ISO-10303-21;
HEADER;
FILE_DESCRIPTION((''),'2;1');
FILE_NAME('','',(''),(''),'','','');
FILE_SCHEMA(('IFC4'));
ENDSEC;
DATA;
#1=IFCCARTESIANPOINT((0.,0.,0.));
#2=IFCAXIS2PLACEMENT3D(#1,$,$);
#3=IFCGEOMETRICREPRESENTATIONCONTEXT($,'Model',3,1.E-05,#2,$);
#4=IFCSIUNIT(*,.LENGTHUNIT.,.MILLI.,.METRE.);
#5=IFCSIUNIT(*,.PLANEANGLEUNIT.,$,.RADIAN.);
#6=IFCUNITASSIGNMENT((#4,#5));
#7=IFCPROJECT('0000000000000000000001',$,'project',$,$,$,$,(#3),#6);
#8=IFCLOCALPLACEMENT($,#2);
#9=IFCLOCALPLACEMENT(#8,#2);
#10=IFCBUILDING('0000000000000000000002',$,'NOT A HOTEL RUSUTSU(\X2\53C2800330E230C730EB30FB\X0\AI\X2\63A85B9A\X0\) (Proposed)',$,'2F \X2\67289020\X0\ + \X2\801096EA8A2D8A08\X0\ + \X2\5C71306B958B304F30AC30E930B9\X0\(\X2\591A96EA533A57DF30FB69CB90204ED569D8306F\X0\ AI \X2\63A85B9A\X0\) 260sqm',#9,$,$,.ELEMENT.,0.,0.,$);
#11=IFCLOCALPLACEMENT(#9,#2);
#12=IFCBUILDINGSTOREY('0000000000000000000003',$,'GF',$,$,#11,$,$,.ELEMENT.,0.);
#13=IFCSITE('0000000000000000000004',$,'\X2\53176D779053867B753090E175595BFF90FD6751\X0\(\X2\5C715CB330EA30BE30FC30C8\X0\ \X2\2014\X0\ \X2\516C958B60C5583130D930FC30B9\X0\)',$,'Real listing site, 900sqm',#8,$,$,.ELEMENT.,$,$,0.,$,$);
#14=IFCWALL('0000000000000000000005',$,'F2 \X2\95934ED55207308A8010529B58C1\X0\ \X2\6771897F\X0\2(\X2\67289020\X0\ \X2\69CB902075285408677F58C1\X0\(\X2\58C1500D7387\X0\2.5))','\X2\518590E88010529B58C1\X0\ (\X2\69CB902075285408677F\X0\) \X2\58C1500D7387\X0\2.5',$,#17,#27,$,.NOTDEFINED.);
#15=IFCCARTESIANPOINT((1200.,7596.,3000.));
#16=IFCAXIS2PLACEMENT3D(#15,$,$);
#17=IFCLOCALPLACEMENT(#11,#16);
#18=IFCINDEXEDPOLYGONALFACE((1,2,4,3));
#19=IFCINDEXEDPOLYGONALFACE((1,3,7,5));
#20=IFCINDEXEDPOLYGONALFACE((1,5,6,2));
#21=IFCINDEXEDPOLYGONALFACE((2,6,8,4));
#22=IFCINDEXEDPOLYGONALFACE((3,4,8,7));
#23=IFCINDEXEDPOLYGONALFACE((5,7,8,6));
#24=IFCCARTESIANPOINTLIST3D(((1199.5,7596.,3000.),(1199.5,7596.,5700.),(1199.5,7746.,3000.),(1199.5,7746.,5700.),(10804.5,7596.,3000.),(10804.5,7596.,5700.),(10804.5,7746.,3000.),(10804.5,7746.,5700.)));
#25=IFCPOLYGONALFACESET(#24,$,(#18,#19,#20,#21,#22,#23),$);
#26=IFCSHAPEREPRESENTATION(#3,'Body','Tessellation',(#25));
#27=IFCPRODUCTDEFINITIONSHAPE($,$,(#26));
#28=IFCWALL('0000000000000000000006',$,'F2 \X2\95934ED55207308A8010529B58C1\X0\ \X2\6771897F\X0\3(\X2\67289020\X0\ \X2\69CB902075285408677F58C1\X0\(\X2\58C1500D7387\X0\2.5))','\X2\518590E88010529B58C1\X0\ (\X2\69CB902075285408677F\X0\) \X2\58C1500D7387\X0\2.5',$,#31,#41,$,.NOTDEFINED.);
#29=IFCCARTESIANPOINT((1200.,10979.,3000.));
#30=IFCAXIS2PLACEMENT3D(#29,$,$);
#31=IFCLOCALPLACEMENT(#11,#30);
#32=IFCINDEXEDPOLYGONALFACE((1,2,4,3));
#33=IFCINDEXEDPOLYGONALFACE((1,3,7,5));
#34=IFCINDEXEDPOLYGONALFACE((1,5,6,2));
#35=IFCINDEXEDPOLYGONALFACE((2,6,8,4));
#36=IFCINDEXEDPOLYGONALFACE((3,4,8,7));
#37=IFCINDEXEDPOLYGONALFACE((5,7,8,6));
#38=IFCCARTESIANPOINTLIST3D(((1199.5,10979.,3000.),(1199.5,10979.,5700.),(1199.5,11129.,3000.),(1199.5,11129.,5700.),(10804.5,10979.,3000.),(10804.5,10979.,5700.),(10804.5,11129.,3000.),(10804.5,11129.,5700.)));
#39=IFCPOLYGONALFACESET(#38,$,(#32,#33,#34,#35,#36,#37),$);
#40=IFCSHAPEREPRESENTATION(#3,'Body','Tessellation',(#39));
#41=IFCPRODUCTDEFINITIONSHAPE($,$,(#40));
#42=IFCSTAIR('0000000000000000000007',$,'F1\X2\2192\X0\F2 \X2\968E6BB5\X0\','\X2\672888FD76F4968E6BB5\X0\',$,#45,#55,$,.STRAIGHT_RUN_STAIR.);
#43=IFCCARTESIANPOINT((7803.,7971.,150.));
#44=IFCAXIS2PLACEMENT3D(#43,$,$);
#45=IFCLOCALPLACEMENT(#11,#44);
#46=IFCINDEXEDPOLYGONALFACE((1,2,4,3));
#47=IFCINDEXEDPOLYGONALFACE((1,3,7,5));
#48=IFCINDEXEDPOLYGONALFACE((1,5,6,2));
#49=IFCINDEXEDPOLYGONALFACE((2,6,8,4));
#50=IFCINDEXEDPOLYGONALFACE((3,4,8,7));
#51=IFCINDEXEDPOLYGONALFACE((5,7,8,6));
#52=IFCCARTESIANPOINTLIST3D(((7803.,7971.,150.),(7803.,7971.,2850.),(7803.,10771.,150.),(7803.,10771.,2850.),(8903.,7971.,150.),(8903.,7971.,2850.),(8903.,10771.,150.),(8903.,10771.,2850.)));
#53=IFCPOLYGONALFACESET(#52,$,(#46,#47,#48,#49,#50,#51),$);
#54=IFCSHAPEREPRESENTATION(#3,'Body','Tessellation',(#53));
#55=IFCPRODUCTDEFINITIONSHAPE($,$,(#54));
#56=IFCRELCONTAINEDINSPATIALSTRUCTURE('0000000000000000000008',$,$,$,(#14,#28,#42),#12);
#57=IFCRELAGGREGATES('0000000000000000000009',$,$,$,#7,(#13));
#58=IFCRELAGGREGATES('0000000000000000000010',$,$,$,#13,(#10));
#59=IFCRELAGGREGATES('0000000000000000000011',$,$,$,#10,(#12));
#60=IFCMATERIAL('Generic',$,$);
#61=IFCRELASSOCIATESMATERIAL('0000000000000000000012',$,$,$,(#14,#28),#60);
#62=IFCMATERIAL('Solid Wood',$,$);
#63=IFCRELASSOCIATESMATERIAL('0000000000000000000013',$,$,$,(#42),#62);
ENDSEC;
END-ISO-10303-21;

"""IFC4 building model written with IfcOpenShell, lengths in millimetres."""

from ifc_helpers import new_model, si_unit, frame, frame_2d, origin, place, context, project, spatial, rectangle, extrude, material, element, save


model = new_model("IFC4")

# Units and contexts
model_context = context("Model", 3, precision=1e-05, world=origin())
ifc_project = project(units=[si_unit("LENGTHUNIT", "METRE", prefix="MILLI"), si_unit("PLANEANGLEUNIT", "RADIAN")], contexts=[model_context])

# Site, building, storey
site_placement = place(None, origin())
site = spatial("IfcSite", under=ifc_project, at=site_placement, Name="北海道虻田郡留寿都村(山岳リゾート — 公開情報ベース)", ObjectType="Real listing site, 900sqm", CompositionType="ELEMENT", RefElevation=0.0)
building_placement = place(site_placement, origin())
building = spatial("IfcBuilding", under=site, at=building_placement, Name="NOT A HOTEL RUSUTSU(参考モデル・AI推定) (Proposed)", ObjectType="2F 木造 + 耐雪設計 + 山に開くガラス(多雪区域・構造仕様は AI 推定) 260sqm", CompositionType="ELEMENT", ElevationOfRefHeight=0.0, ElevationOfTerrain=0.0)
storey_placement = place(building_placement, origin())
storey = spatial("IfcBuildingStorey", under=building, at=storey_placement, Name="GF", CompositionType="ELEMENT", Elevation=0.0)

# Shared definitions
ifc_material_1 = material(Name="Generic")

# Walls
wall_1_placement = place(storey_placement, frame((1200.0, 7596.0, 3000.0)))
element("IfcWall", 1, at=wall_1_placement, inside=storey, material=ifc_material_1, Name="F2 間仕切り耐力壁 東西2(木造 構造用合板壁(壁倍率2.5))", Description="内部耐力壁 (構造用合板) 壁倍率2.5", PredefinedType="NOTDEFINED", context=model_context, shape_type="SweptSolid", body=[
    extrude(rectangle(XDim=9605.0, YDim=150.0, at=frame_2d((4802.0, 75.0))), frame((1200.0, 7596.0, 3000.0)), (0.0, 0.0, 1.0), 2700.0),
])
wall_2_placement = place(storey_placement, frame((1200.0, 10979.0, 3000.0)))
element("IfcWall", 2, at=wall_2_placement, inside=storey, material=ifc_material_1, Name="F2 間仕切り耐力壁 東西3(木造 構造用合板壁(壁倍率2.5))", Description="内部耐力壁 (構造用合板) 壁倍率2.5", PredefinedType="NOTDEFINED", context=model_context, shape_type="SweptSolid", body=[
    extrude(rectangle(XDim=9605.0, YDim=150.0, at=frame_2d((4802.0, 75.0))), frame((1200.0, 10979.0, 3000.0)), (0.0, 0.0, 1.0), 2700.0),
])

# Stair
ifc_material_2 = material(Name="Solid Wood")
stair_placement = place(storey_placement, frame((7803.0, 7971.0, 150.0)))
element("IfcStair", 3, at=stair_placement, inside=storey, material=ifc_material_2, Name="F1→F2 階段", Description="木製直階段", PredefinedType="STRAIGHT_RUN_STAIR", context=model_context, shape_type="SweptSolid", body=[
    extrude(rectangle(XDim=1100.0, YDim=2800.0, at=frame_2d((550.0, 1400.0))), frame((7803.0, 7971.0, 150.0)), (0.0, 0.0, 1.0), 2700.0),
])

save(model, "model.ifc")
